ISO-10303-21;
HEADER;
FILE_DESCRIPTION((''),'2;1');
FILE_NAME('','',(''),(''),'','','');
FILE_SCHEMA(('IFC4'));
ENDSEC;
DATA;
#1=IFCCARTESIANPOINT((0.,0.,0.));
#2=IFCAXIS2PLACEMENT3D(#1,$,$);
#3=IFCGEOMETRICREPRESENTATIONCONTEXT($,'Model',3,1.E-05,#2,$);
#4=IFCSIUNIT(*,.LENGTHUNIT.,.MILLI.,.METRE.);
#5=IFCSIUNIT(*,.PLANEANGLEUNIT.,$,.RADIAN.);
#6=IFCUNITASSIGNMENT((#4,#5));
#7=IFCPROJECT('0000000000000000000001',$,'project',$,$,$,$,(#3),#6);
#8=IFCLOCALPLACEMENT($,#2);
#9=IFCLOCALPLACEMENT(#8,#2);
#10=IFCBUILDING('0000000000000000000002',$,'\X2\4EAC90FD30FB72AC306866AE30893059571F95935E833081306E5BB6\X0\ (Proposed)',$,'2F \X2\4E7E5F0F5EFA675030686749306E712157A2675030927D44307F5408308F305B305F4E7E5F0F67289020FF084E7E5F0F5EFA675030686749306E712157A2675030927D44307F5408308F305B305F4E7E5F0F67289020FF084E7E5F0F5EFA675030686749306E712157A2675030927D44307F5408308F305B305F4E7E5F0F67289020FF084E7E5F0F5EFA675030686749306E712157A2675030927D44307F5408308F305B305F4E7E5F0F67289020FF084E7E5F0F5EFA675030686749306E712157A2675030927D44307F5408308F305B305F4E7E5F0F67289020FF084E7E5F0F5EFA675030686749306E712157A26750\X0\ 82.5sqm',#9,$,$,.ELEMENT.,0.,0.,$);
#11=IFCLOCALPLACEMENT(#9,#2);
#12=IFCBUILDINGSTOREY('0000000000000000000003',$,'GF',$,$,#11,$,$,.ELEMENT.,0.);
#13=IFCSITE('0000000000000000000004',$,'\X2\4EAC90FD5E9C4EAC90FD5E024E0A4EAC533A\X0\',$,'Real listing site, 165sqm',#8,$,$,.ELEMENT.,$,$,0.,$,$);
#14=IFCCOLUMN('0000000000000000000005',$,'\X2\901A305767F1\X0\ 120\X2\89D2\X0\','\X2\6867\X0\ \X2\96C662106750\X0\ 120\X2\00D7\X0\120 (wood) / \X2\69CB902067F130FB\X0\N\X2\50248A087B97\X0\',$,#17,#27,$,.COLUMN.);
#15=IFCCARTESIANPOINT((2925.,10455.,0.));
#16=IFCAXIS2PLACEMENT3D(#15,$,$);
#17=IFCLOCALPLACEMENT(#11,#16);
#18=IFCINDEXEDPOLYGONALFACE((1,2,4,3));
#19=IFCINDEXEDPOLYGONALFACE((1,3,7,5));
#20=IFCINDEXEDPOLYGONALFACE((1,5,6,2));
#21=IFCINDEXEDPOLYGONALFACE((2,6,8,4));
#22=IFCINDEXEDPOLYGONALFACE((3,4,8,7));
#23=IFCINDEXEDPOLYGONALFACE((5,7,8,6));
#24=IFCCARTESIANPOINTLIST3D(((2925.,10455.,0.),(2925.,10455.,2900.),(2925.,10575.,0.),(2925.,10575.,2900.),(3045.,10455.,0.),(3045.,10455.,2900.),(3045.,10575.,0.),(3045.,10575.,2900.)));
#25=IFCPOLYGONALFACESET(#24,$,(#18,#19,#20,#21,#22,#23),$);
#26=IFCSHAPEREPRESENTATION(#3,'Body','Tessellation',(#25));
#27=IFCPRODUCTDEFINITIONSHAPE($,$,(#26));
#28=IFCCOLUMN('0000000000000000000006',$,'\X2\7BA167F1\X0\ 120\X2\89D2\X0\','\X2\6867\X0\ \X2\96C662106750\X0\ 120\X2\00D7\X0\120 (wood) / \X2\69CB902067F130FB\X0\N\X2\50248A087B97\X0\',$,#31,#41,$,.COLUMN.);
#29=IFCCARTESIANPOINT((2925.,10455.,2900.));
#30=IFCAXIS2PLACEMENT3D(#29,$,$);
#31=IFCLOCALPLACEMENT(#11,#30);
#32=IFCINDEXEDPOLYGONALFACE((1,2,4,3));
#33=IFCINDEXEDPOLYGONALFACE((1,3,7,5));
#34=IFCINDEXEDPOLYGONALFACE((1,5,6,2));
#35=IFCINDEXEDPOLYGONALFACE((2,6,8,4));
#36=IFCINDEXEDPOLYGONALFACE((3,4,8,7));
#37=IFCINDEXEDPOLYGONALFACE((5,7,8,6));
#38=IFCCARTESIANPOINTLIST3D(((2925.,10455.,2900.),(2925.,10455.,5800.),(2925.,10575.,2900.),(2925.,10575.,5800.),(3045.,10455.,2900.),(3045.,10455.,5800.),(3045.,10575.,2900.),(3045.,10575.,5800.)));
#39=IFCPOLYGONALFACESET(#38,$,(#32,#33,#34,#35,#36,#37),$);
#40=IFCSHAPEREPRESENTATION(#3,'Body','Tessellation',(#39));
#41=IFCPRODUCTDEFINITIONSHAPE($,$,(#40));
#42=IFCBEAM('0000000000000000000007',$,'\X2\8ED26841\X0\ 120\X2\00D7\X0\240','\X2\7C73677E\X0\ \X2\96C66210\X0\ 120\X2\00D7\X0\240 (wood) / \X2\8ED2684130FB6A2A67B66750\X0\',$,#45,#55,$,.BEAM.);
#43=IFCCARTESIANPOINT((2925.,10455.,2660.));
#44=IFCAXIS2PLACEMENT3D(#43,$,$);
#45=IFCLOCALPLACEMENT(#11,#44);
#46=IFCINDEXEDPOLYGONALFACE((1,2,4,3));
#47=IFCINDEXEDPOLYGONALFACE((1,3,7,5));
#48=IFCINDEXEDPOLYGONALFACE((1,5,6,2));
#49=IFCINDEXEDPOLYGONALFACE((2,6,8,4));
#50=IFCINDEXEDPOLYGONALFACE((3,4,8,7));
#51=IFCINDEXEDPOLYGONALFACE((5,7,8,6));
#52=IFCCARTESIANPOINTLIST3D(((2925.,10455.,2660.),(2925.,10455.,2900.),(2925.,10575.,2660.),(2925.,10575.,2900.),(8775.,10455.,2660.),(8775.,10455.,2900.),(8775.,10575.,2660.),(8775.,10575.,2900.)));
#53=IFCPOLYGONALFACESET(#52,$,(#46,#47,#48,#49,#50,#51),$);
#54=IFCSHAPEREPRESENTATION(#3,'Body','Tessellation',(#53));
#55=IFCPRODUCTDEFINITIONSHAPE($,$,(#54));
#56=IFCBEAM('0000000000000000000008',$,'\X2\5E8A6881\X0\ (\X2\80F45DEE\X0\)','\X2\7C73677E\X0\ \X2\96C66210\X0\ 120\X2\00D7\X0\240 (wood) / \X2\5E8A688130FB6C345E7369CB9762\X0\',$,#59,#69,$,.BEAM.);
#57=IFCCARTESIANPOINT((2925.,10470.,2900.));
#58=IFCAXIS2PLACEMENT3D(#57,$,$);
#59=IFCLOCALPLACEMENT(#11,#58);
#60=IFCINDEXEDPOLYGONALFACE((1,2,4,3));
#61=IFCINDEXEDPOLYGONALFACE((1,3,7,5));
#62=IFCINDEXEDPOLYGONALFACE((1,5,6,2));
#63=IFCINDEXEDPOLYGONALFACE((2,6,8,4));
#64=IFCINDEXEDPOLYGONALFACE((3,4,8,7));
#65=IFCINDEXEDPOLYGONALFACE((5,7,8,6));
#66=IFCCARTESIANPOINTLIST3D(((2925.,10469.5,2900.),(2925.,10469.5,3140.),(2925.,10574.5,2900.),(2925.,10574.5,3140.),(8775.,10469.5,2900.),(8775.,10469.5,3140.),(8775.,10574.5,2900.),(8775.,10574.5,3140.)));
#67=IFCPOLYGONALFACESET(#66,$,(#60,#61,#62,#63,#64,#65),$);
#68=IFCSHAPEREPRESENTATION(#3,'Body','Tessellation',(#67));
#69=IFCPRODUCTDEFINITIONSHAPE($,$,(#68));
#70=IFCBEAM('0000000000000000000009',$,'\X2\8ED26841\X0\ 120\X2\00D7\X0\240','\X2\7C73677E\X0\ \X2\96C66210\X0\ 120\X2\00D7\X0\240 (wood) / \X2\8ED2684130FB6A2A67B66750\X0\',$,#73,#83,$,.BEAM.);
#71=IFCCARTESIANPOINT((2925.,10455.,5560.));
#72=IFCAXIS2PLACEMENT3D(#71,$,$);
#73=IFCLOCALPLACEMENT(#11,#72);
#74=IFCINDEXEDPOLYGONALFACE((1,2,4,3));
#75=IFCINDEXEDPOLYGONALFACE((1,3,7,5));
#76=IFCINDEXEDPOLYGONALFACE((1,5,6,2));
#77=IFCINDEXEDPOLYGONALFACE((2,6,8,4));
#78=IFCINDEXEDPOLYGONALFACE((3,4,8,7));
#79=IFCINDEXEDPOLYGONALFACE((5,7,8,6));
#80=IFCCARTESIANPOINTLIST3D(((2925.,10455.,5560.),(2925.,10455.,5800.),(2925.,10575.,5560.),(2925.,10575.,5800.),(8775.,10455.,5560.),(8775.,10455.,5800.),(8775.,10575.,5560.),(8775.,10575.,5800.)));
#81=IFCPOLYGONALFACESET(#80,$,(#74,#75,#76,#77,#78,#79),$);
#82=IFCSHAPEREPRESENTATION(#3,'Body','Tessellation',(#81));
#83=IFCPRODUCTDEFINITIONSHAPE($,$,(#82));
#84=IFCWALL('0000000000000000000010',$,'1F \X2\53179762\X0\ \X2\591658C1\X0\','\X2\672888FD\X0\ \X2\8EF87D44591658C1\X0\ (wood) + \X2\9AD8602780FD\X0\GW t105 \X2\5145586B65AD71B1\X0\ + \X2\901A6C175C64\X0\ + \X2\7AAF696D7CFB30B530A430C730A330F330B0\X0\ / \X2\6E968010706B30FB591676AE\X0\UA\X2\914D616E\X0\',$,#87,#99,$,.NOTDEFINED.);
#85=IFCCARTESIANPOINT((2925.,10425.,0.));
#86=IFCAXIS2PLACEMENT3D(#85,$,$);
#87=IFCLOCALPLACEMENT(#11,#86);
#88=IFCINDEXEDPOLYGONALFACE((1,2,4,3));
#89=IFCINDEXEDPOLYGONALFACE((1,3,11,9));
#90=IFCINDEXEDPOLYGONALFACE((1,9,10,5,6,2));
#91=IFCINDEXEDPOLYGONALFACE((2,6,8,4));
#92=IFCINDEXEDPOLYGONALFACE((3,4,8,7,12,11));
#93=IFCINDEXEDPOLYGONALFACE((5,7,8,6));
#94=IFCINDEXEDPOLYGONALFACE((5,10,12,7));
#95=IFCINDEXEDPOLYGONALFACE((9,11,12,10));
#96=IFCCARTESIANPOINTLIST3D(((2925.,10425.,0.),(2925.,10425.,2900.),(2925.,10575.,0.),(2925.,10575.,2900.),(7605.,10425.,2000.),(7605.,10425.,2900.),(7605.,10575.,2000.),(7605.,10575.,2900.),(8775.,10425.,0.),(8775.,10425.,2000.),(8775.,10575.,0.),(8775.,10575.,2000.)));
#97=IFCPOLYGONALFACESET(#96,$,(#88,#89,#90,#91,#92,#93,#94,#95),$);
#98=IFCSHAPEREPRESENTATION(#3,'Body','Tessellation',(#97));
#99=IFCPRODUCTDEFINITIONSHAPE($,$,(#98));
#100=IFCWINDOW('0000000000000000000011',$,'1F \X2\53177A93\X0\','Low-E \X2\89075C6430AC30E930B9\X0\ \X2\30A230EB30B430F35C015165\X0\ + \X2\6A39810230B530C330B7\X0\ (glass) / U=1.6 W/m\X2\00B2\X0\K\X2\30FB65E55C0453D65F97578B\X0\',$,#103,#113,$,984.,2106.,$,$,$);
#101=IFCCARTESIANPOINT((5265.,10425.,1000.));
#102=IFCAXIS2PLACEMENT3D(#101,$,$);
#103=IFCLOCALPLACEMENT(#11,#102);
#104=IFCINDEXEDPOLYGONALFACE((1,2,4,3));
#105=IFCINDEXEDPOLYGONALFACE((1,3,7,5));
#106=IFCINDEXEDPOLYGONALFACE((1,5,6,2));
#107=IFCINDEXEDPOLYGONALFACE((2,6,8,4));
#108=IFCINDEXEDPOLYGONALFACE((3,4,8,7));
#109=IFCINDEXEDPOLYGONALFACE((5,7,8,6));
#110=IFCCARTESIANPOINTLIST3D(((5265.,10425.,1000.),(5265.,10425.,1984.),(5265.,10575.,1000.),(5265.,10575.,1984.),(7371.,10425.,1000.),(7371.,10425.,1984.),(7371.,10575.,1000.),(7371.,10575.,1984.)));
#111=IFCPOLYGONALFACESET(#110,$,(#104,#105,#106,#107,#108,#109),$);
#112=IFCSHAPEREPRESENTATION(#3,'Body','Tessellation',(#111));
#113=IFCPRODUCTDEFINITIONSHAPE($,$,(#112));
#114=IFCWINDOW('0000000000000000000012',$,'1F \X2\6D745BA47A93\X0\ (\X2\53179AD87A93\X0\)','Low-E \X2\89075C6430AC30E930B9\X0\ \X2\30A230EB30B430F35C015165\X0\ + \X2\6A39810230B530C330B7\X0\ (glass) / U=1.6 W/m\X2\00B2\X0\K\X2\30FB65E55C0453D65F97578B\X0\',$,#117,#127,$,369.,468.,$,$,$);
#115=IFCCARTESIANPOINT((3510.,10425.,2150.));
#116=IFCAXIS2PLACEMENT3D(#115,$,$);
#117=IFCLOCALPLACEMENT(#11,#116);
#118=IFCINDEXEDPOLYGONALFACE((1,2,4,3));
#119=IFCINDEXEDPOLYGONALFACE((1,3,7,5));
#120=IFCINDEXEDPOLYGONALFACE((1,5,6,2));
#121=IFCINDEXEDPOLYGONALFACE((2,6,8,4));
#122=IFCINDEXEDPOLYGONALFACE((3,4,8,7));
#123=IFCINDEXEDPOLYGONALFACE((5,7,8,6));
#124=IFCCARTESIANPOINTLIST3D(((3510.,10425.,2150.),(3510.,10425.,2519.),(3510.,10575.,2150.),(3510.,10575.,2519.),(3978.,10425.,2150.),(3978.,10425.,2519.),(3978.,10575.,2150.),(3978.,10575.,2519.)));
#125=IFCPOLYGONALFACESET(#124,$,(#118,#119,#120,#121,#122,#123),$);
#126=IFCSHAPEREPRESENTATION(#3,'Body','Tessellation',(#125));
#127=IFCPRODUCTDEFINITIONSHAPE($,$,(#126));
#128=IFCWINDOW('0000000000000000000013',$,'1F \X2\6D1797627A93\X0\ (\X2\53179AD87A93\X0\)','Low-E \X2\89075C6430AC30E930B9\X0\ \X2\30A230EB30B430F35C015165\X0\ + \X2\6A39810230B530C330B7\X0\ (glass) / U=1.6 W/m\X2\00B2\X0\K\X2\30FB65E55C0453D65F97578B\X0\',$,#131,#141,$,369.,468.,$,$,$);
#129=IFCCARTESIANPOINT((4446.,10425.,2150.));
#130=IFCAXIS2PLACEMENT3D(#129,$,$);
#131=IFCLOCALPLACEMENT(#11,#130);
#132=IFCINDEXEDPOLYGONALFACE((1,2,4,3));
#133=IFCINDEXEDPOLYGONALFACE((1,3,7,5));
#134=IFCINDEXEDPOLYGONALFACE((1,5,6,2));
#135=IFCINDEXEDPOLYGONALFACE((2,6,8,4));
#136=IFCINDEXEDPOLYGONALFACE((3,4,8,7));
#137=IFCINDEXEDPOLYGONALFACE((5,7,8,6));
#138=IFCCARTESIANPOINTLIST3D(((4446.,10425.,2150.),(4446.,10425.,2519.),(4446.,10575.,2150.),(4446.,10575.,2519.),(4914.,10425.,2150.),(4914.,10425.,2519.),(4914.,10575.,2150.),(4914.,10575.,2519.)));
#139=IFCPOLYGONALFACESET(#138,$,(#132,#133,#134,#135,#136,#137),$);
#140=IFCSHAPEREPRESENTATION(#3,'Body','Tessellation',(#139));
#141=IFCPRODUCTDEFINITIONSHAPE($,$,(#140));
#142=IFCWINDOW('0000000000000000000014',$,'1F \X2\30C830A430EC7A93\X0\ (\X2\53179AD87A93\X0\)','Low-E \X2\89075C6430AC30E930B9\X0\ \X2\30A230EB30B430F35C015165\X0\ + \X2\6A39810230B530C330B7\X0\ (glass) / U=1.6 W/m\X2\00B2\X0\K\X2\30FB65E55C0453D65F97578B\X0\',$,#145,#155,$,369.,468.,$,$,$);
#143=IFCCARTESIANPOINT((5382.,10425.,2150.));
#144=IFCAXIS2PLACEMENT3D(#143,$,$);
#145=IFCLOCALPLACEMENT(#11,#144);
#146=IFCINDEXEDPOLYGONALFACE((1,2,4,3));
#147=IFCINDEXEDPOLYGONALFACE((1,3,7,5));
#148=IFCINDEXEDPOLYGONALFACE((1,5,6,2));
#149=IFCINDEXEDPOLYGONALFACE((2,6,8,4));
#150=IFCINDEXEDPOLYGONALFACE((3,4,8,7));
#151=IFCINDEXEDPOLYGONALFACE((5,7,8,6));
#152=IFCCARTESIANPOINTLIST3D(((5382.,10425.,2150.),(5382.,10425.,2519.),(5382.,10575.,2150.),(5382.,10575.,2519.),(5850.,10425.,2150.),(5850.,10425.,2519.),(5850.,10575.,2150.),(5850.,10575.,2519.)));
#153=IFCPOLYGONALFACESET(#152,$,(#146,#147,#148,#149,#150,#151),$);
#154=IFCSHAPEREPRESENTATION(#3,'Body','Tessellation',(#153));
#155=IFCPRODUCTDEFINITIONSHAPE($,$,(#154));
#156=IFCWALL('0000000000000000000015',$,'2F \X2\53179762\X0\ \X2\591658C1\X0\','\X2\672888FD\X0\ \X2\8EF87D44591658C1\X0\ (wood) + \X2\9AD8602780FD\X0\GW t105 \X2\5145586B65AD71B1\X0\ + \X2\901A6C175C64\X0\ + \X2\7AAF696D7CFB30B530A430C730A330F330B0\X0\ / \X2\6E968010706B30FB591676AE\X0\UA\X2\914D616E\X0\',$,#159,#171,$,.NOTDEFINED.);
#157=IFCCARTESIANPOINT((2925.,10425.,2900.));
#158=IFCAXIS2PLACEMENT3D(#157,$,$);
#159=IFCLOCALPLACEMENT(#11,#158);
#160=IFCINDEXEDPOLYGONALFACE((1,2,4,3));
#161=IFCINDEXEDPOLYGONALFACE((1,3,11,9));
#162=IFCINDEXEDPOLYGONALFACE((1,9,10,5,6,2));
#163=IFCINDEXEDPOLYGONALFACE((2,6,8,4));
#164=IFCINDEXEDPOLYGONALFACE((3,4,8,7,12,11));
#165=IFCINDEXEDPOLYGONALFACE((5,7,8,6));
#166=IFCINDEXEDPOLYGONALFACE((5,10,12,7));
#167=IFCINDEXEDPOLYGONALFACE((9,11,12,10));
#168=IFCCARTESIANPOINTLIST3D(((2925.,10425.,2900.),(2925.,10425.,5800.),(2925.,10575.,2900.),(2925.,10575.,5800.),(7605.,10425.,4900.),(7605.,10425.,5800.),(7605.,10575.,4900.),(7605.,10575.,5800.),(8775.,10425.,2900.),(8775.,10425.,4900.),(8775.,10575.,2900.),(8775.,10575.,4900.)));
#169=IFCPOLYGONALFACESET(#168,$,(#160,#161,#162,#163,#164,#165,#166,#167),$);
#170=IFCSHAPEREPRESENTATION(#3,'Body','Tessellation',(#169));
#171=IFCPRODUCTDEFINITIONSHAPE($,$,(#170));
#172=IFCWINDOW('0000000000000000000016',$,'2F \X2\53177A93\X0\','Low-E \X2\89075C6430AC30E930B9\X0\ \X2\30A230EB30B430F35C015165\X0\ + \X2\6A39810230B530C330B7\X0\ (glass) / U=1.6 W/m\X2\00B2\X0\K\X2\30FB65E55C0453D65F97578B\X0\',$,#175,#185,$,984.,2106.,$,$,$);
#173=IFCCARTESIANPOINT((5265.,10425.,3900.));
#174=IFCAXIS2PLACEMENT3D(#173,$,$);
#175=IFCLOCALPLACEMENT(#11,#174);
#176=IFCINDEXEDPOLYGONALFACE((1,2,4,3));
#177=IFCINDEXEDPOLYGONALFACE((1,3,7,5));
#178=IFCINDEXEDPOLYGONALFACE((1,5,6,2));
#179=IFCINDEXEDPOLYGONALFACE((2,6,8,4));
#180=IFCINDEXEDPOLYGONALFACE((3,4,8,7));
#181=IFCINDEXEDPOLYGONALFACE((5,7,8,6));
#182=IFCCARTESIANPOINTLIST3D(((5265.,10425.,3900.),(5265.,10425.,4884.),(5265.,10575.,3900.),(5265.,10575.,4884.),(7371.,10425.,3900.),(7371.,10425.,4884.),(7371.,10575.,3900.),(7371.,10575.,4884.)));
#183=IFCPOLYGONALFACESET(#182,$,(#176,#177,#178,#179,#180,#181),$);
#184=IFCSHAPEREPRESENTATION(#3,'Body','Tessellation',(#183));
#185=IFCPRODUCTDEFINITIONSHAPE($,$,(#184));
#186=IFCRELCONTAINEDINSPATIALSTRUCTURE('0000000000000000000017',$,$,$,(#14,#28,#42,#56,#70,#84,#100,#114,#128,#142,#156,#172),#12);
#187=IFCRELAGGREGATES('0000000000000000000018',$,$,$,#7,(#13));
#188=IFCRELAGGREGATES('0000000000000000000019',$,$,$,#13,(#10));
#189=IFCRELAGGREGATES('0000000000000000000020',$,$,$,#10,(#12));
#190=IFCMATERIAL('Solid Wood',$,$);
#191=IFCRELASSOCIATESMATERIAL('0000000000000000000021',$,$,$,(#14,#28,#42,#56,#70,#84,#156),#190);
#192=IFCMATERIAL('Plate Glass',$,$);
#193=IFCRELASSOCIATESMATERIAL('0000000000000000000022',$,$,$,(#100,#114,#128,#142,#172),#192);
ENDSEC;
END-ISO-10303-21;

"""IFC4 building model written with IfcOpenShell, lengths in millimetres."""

from ifc_helpers import new_model, si_unit, frame, frame_2d, origin, place, context, project, spatial, rectangle, extrude, material, element, fill, save


model = new_model("IFC4")

# Units and contexts
model_context = context("Model", 3, precision=1e-05, world=origin())
ifc_project = project(units=[si_unit("LENGTHUNIT", "METRE", prefix="MILLI"), si_unit("PLANEANGLEUNIT", "RADIAN")], contexts=[model_context])

# Site, building, storey
site_placement = place(None, origin())
site = spatial("IfcSite", under=ifc_project, at=site_placement, Name="京都府京都市上京区", ObjectType="Real listing site, 165sqm", CompositionType="ELEMENT", RefElevation=0.0)
building_placement = place(site_placement, origin())
building = spatial("IfcBuilding", under=site, at=building_placement, Name="京都・犬と暮らす土間広めの家 (Proposed)", ObjectType="2F 乾式建材と杉の無垢材を組み合わせた乾式木造（乾式建材と杉の無垢材を組み合わせた乾式木造（乾式建材と杉の無垢材を組み合わせた乾式木造（乾式建材と杉の無垢材を組み合わせた乾式木造（乾式建材と杉の無垢材を組み合わせた乾式木造（乾式建材と杉の無垢材 82.5sqm", CompositionType="ELEMENT", ElevationOfRefHeight=0.0, ElevationOfTerrain=0.0)
storey_placement = place(building_placement, origin())
storey = spatial("IfcBuildingStorey", under=building, at=storey_placement, Name="GF", CompositionType="ELEMENT", Elevation=0.0)

# Columns
ifc_material_1 = material(Name="Solid Wood")
column_1_placement = place(storey_placement, frame((2925.0, 10455.0, 0.0)))
element("IfcColumn", 1, at=column_1_placement, inside=storey, material=ifc_material_1, Name="通し柱 120角", Description="桧 集成材 120×120 (wood) / 構造柱・N値計算", PredefinedType="COLUMN", context=model_context, shape_type="SweptSolid", body=[
    extrude(rectangle(XDim=120.0, YDim=120.0, at=frame_2d((60.0, 60.0))), frame((2925.0, 10455.0, 0.0)), (0.0, 0.0, 1.0), 2900.0),
])
column_2_placement = place(storey_placement, frame((2925.0, 10455.0, 2900.0)))
element("IfcColumn", 2, at=column_2_placement, inside=storey, material=ifc_material_1, Name="管柱 120角", Description="桧 集成材 120×120 (wood) / 構造柱・N値計算", PredefinedType="COLUMN", context=model_context, shape_type="SweptSolid", body=[
    extrude(rectangle(XDim=120.0, YDim=120.0, at=frame_2d((60.0, 60.0))), frame((2925.0, 10455.0, 2900.0)), (0.0, 0.0, 1.0), 2900.0),
])

# Beams
beam_1_placement = place(storey_placement, frame((2925.0, 10455.0, 2660.0)))
element("IfcBeam", 3, at=beam_1_placement, inside=storey, material=ifc_material_1, Name="軒桁 120×240", Description="米松 集成 120×240 (wood) / 軒桁・横架材", PredefinedType="BEAM", context=model_context, shape_type="SweptSolid", body=[
    extrude(rectangle(XDim=5850.0, YDim=120.0, at=frame_2d((2925.0, 60.0))), frame((2925.0, 10455.0, 2660.0)), (0.0, 0.0, 1.0), 240.0),
])
beam_2_placement = place(storey_placement, frame((2925.0, 10470.0, 2900.0)))
element("IfcBeam", 4, at=beam_2_placement, inside=storey, material=ifc_material_1, Name="床梁 (胴差)", Description="米松 集成 120×240 (wood) / 床梁・水平構面", PredefinedType="BEAM", context=model_context, shape_type="SweptSolid", body=[
    extrude(rectangle(XDim=5850.0, YDim=105.0, at=frame_2d((2925.0, 52.0))), frame((2925.0, 10470.0, 2900.0)), (0.0, 0.0, 1.0), 240.0),
])
beam_3_placement = place(storey_placement, frame((2925.0, 10455.0, 5560.0)))
element("IfcBeam", 5, at=beam_3_placement, inside=storey, material=ifc_material_1, Name="軒桁 120×240", Description="米松 集成 120×240 (wood) / 軒桁・横架材", PredefinedType="BEAM", context=model_context, shape_type="SweptSolid", body=[
    extrude(rectangle(XDim=5850.0, YDim=120.0, at=frame_2d((2925.0, 60.0))), frame((2925.0, 10455.0, 5560.0)), (0.0, 0.0, 1.0), 240.0),
])

# Wall, openings, windows
wall_1_placement = place(storey_placement, frame((2925.0, 10425.0, 0.0)))
wall_1 = element("IfcWall", 6, at=wall_1_placement, inside=storey, material=ifc_material_1, Name="1F 北面 外壁", Description="木製 軸組外壁 (wood) + 高性能GW t105 充填断熱 + 通気層 + 窯業系サイディング / 準耐火・外皮UA配慮", PredefinedType="NOTDEFINED", context=model_context, shape_type="SweptSolid", body=[
    extrude(rectangle(XDim=5850.0, YDim=150.0, at=frame_2d((2925.0, 75.0))), frame((2925.0, 10425.0, 0.0)), (0.0, 0.0, 1.0), 2900.0),
])
opening_1_placement = place(storey_placement, frame((5265.0, 10425.0, 1000.0)))
opening_1 = element("IfcOpeningElement", 7, at=opening_1_placement, cuts=wall_1, PredefinedType="NOTDEFINED", context=model_context, shape_type="SweptSolid", body=[
    extrude(rectangle(XDim=2106.0, YDim=150.0, at=frame_2d((1053.0, 75.0))), frame((5265.0, 10425.0, 1000.0)), (0.0, 0.0, 1.0), 984.0),
])
opening_2_placement = place(storey_placement, frame((3510.0, 10425.0, 2150.0)))
opening_2 = element("IfcOpeningElement", 8, at=opening_2_placement, cuts=wall_1, PredefinedType="NOTDEFINED", context=model_context, shape_type="SweptSolid", body=[
    extrude(rectangle(XDim=468.0, YDim=150.0, at=frame_2d((234.0, 75.0))), frame((3510.0, 10425.0, 2150.0)), (0.0, 0.0, 1.0), 369.0),
])
opening_3_placement = place(storey_placement, frame((4446.0, 10425.0, 2150.0)))
opening_3 = element("IfcOpeningElement", 9, at=opening_3_placement, cuts=wall_1, PredefinedType="NOTDEFINED", context=model_context, shape_type="SweptSolid", body=[
    extrude(rectangle(XDim=468.0, YDim=150.0, at=frame_2d((234.0, 75.0))), frame((4446.0, 10425.0, 2150.0)), (0.0, 0.0, 1.0), 369.0),
])
opening_4_placement = place(storey_placement, frame((5382.0, 10425.0, 2150.0)))
opening_4 = element("IfcOpeningElement", 10, at=opening_4_placement, cuts=wall_1, PredefinedType="NOTDEFINED", context=model_context, shape_type="SweptSolid", body=[
    extrude(rectangle(XDim=468.0, YDim=150.0, at=frame_2d((234.0, 75.0))), frame((5382.0, 10425.0, 2150.0)), (0.0, 0.0, 1.0), 369.0),
])
ifc_material_2 = material(Name="Plate Glass")
window_1_placement = place(storey_placement, frame((5265.0, 10425.0, 1000.0)))
window_1 = element("IfcWindow", 11, at=window_1_placement, inside=storey, material=ifc_material_2, Name="1F 北窓", Description="Low-E 複層ガラス アルゴン封入 + 樹脂サッシ (glass) / U=1.6 W/m²K・日射取得型", OverallHeight=984.0, OverallWidth=2106.0, context=model_context, shape_type="SweptSolid", body=[
    extrude(rectangle(XDim=2106.0, YDim=150.0, at=frame_2d((1053.0, 75.0))), frame((5265.0, 10425.0, 1000.0)), (0.0, 0.0, 1.0), 984.0),
])
fill(opening_1, window_1)
window_2_placement = place(storey_placement, frame((3510.0, 10425.0, 2150.0)))
window_2 = element("IfcWindow", 12, at=window_2_placement, inside=storey, material=ifc_material_2, Name="1F 浴室窓 (北高窓)", Description="Low-E 複層ガラス アルゴン封入 + 樹脂サッシ (glass) / U=1.6 W/m²K・日射取得型", OverallHeight=369.0, OverallWidth=468.0, context=model_context, shape_type="SweptSolid", body=[
    extrude(rectangle(XDim=468.0, YDim=150.0, at=frame_2d((234.0, 75.0))), frame((3510.0, 10425.0, 2150.0)), (0.0, 0.0, 1.0), 369.0),
])
fill(opening_2, window_2)
window_3_placement = place(storey_placement, frame((4446.0, 10425.0, 2150.0)))
window_3 = element("IfcWindow", 13, at=window_3_placement, inside=storey, material=ifc_material_2, Name="1F 洗面窓 (北高窓)", Description="Low-E 複層ガラス アルゴン封入 + 樹脂サッシ (glass) / U=1.6 W/m²K・日射取得型", OverallHeight=369.0, OverallWidth=468.0, context=model_context, shape_type="SweptSolid", body=[
    extrude(rectangle(XDim=468.0, YDim=150.0, at=frame_2d((234.0, 75.0))), frame((4446.0, 10425.0, 2150.0)), (0.0, 0.0, 1.0), 369.0),
])
fill(opening_3, window_3)
window_4_placement = place(storey_placement, frame((5382.0, 10425.0, 2150.0)))
window_4 = element("IfcWindow", 14, at=window_4_placement, inside=storey, material=ifc_material_2, Name="1F トイレ窓 (北高窓)", Description="Low-E 複層ガラス アルゴン封入 + 樹脂サッシ (glass) / U=1.6 W/m²K・日射取得型", OverallHeight=369.0, OverallWidth=468.0, context=model_context, shape_type="SweptSolid", body=[
    extrude(rectangle(XDim=468.0, YDim=150.0, at=frame_2d((234.0, 75.0))), frame((5382.0, 10425.0, 2150.0)), (0.0, 0.0, 1.0), 369.0),
])
fill(opening_4, window_4)

# Wall, opening, window
wall_2_placement = place(storey_placement, frame((2925.0, 10425.0, 2900.0)))
wall_2 = element("IfcWall", 15, at=wall_2_placement, inside=storey, material=ifc_material_1, Name="2F 北面 外壁", Description="木製 軸組外壁 (wood) + 高性能GW t105 充填断熱 + 通気層 + 窯業系サイディング / 準耐火・外皮UA配慮", PredefinedType="NOTDEFINED", context=model_context, shape_type="SweptSolid", body=[
    extrude(rectangle(XDim=5850.0, YDim=150.0, at=frame_2d((2925.0, 75.0))), frame((2925.0, 10425.0, 2900.0)), (0.0, 0.0, 1.0), 2900.0),
])
opening_5_placement = place(storey_placement, frame((5265.0, 10425.0, 3900.0)))
opening_5 = element("IfcOpeningElement", 16, at=opening_5_placement, cuts=wall_2, PredefinedType="NOTDEFINED", context=model_context, shape_type="SweptSolid", body=[
    extrude(rectangle(XDim=2106.0, YDim=150.0, at=frame_2d((1053.0, 75.0))), frame((5265.0, 10425.0, 3900.0)), (0.0, 0.0, 1.0), 984.0),
])
window_5_placement = place(storey_placement, frame((5265.0, 10425.0, 3900.0)))
window_5 = element("IfcWindow", 17, at=window_5_placement, inside=storey, material=ifc_material_2, Name="2F 北窓", Description="Low-E 複層ガラス アルゴン封入 + 樹脂サッシ (glass) / U=1.6 W/m²K・日射取得型", OverallHeight=984.0, OverallWidth=2106.0, context=model_context, shape_type="SweptSolid", body=[
    extrude(rectangle(XDim=2106.0, YDim=150.0, at=frame_2d((1053.0, 75.0))), frame((5265.0, 10425.0, 3900.0)), (0.0, 0.0, 1.0), 984.0),
])
fill(opening_5, window_5)

save(model, "model.ifc")
